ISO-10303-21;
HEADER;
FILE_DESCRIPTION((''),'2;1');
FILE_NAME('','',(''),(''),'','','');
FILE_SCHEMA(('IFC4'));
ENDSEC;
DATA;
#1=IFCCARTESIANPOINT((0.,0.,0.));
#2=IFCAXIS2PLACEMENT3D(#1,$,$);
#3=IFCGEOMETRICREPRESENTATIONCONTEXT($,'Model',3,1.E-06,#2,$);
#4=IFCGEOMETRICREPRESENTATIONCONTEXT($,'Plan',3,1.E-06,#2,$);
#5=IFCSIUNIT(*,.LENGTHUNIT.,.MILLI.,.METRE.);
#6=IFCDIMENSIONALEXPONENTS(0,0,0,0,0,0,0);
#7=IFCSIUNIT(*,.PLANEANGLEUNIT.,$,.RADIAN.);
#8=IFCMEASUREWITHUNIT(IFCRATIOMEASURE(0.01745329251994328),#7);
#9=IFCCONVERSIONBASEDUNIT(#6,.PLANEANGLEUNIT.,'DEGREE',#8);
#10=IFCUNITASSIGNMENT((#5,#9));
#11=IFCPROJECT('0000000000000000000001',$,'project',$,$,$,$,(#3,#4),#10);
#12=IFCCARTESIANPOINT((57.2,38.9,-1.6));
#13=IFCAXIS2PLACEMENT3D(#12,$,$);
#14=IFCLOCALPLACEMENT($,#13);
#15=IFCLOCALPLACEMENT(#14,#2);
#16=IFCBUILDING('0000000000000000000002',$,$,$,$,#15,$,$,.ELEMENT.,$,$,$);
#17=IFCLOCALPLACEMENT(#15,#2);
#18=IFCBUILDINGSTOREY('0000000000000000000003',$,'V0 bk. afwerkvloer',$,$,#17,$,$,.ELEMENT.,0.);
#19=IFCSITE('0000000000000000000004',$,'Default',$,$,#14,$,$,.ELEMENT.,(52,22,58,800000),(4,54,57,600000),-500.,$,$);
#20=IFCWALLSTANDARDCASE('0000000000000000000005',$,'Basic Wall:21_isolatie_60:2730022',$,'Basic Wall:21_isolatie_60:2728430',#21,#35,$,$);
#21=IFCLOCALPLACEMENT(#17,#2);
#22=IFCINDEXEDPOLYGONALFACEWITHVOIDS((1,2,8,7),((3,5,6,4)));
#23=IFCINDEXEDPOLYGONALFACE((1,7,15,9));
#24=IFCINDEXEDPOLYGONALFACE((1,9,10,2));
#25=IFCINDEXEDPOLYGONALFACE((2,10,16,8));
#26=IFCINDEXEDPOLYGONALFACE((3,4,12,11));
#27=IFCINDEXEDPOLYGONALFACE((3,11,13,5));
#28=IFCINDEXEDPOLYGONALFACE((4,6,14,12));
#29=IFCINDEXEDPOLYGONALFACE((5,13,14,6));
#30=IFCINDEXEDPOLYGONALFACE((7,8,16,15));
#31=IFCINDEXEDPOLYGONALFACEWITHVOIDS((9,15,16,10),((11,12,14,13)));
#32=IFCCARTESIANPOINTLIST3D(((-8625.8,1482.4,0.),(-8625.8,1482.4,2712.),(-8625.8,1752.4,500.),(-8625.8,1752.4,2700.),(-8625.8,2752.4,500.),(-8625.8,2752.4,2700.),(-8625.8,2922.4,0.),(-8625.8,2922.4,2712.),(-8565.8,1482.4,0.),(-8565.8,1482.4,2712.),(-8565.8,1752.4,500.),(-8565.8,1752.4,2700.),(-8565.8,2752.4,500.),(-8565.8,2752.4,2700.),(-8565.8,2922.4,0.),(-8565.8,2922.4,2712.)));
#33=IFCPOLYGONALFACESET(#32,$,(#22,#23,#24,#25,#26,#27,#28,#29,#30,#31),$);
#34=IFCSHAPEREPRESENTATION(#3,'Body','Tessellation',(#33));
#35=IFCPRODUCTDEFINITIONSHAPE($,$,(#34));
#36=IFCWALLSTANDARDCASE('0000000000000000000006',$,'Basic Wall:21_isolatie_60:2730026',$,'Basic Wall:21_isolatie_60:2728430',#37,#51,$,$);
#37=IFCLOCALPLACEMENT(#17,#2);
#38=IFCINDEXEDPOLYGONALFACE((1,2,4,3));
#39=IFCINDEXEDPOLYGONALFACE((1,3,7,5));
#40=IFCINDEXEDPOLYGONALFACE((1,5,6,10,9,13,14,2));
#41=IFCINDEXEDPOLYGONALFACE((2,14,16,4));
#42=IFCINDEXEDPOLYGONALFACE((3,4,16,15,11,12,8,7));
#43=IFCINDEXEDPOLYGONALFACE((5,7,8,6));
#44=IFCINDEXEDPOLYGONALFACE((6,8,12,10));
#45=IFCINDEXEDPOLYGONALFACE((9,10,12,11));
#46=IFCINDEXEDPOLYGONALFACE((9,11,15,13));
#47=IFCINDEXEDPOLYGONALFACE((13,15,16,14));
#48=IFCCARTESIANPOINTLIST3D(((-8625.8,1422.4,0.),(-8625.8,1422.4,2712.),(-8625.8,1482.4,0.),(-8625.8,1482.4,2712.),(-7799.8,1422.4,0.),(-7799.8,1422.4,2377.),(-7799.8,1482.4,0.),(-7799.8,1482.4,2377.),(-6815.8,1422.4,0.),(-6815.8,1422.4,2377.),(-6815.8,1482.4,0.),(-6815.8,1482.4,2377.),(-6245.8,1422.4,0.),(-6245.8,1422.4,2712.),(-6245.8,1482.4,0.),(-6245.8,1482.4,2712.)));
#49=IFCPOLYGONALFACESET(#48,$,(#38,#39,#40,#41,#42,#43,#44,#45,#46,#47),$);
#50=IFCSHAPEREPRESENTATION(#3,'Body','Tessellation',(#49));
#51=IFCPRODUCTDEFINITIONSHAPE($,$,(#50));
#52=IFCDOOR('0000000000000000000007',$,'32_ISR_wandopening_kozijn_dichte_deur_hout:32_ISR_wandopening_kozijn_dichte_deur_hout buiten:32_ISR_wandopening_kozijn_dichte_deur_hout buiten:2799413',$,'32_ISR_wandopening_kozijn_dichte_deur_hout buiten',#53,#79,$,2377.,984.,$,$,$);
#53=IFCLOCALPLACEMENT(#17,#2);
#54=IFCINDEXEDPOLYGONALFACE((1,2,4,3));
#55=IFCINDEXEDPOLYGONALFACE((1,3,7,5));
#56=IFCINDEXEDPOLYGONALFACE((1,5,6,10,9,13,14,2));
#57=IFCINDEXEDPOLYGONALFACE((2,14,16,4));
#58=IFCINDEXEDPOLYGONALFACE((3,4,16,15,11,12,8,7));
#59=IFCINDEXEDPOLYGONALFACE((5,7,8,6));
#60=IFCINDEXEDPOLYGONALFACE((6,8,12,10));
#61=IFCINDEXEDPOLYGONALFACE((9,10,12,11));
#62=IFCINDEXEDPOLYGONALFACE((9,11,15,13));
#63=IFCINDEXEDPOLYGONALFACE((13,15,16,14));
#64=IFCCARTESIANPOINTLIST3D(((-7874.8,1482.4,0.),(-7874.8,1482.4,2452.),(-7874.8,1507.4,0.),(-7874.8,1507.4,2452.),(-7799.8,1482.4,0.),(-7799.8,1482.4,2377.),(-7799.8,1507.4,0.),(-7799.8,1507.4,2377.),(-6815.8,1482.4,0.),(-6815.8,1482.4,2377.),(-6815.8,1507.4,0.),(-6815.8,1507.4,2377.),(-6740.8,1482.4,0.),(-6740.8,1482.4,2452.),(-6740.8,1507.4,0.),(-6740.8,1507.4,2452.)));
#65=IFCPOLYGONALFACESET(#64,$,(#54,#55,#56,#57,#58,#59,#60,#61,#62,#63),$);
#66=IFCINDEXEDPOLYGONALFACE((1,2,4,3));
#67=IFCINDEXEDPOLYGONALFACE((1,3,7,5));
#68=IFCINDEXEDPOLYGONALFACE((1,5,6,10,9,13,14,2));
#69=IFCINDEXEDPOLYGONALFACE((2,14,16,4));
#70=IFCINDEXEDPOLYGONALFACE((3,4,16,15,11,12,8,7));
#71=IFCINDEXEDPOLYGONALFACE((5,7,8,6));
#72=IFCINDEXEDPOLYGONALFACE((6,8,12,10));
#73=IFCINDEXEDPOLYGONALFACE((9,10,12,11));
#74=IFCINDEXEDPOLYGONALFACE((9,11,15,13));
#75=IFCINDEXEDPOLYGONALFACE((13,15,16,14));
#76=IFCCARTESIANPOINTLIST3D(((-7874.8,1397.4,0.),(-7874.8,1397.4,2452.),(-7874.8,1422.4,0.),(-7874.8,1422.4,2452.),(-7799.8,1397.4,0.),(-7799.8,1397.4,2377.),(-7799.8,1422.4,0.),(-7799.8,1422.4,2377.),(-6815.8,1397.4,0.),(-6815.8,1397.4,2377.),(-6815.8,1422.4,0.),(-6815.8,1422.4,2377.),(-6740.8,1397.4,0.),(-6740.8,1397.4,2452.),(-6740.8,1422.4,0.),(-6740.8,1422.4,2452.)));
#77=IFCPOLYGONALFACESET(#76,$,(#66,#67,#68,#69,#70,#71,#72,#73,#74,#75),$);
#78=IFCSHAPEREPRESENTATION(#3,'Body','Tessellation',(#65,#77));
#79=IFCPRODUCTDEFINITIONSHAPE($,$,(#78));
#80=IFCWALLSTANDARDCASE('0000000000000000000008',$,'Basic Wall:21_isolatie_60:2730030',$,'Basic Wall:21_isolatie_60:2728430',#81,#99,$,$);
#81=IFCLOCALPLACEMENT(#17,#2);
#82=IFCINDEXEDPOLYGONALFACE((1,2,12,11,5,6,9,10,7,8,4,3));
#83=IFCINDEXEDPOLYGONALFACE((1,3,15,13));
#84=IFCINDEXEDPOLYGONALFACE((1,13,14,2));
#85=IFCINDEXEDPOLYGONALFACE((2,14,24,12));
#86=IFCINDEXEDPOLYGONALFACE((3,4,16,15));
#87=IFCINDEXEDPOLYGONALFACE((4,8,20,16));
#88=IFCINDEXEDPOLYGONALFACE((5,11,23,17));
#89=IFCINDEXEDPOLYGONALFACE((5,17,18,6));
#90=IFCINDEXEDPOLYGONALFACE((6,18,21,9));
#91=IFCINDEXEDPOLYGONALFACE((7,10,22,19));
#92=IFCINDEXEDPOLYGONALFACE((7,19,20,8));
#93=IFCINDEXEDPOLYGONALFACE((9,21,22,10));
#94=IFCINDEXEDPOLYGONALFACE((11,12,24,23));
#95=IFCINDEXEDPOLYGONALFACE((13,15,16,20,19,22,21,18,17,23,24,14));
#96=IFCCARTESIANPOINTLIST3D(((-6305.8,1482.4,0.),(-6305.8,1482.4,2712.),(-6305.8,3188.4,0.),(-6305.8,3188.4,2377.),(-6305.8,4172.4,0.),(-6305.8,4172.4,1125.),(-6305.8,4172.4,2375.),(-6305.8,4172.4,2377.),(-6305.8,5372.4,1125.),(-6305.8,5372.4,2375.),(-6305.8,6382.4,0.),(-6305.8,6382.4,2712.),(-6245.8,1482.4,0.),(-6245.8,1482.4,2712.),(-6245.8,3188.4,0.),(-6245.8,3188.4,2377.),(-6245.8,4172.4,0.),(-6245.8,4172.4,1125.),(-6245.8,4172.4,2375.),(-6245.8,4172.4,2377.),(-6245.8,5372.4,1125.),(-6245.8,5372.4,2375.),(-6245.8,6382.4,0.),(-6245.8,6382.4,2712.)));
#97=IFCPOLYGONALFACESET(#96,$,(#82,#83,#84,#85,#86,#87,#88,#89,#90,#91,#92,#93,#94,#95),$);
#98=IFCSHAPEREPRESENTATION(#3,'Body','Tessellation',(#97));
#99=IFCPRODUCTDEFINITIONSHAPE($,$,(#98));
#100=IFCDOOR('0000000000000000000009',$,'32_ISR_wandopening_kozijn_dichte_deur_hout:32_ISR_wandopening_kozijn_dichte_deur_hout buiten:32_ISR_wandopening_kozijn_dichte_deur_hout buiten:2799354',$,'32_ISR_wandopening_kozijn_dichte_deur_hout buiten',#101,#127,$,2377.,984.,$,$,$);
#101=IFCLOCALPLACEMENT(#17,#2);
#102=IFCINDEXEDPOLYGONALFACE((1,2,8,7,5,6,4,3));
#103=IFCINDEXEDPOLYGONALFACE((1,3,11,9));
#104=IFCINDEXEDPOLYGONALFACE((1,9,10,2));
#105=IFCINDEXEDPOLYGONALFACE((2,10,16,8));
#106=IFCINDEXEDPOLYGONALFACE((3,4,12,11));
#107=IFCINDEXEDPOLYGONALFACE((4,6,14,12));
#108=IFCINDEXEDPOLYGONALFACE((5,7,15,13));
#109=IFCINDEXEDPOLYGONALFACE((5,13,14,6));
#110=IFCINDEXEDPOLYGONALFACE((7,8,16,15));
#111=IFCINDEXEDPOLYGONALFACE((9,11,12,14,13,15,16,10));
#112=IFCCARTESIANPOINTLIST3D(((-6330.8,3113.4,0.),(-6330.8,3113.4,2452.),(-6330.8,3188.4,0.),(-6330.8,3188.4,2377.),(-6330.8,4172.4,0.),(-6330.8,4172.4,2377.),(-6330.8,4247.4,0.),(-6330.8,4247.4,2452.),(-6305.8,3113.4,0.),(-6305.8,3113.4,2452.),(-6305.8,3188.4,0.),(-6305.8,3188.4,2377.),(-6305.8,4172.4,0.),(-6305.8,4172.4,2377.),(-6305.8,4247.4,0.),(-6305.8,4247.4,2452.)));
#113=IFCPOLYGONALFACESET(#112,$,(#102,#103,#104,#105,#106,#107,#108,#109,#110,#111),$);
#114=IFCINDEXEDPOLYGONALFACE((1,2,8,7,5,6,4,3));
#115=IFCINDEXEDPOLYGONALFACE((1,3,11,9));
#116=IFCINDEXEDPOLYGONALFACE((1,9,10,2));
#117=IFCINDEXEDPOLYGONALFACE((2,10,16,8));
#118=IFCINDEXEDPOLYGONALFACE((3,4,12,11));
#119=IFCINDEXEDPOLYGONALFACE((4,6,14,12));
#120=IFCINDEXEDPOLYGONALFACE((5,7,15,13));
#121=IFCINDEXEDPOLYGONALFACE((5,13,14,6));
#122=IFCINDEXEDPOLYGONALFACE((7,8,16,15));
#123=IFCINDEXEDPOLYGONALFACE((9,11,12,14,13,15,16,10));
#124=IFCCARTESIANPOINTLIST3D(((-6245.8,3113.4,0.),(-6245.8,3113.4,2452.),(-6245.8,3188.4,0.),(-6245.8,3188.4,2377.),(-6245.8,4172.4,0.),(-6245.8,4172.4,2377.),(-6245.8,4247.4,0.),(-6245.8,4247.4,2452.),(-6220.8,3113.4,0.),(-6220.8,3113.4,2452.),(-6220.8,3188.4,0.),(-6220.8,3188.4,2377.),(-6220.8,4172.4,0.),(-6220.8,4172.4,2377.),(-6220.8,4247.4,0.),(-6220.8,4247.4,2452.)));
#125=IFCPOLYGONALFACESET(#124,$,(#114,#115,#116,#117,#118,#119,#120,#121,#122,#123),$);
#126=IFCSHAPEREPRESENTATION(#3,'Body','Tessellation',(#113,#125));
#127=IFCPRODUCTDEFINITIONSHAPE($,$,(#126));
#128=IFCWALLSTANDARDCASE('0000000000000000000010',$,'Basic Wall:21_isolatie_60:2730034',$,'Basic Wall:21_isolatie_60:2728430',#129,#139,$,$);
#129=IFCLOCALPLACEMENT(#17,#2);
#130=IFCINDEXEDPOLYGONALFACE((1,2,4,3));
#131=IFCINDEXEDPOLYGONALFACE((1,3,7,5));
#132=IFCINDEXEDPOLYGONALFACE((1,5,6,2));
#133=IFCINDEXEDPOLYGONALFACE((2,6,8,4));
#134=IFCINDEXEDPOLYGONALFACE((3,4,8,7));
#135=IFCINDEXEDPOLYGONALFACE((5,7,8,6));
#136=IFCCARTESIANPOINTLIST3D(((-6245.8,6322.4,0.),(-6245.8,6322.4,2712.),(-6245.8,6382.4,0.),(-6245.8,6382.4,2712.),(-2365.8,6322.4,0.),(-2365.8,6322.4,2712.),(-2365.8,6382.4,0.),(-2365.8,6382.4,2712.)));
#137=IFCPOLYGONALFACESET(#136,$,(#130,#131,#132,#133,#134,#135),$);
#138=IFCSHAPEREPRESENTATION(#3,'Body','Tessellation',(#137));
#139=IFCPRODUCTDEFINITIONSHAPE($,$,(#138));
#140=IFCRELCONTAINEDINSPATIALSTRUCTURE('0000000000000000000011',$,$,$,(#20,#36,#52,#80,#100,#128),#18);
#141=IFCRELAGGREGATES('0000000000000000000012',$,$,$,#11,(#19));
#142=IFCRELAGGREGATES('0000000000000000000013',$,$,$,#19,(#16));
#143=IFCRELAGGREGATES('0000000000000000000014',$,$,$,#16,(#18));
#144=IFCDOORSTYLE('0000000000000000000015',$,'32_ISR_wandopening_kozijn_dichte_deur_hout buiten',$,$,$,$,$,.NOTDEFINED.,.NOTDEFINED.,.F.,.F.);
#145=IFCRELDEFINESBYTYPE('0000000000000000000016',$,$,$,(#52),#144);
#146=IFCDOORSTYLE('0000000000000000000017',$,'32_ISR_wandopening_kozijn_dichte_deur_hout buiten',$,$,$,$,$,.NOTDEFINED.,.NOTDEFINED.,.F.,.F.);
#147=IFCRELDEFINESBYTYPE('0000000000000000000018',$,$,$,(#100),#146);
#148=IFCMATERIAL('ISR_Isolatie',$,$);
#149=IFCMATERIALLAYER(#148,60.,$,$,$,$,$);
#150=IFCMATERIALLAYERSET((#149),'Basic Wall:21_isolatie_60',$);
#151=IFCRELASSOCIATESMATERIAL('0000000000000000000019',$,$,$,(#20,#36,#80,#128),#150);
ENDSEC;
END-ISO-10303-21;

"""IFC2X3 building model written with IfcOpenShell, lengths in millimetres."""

from ifc_helpers import new_model, entity, si_unit, converted_unit, frame, frame_2d, origin, origin_2d_with_axis, place, context, project, spatial, polyline, rectangle, outline, extrude, source, transform, mapped, material, layer, layer_set, layer_usage, type_object, type_shapes, element, fill, save


model = new_model("IFC2X3")

# Units and contexts
model_context = context("Model", 3, precision=1e-06, world=origin())
plan_context = context("Plan", 3, precision=1e-06, world=origin())
ifc_project = project(units=[si_unit("LENGTHUNIT", "METRE", prefix="MILLI"), converted_unit("PLANEANGLEUNIT", "DEGREE", entity("IfcRatioMeasure", 0.01745329251994328), si_unit("PLANEANGLEUNIT", "RADIAN"), dimensions=[0, 0, 0, 0, 0, 0, 0])], contexts=[model_context, plan_context])

# Site, building, storey
site_placement = place(None, frame((57.2, 38.9, -1.6)))
site = spatial("IfcSite", under=ifc_project, at=site_placement, Name="Default", CompositionType="ELEMENT", RefLatitude=(52, 22, 58, 800000), RefLongitude=(4, 54, 57, 600000), RefElevation=-500.0)
building_placement = place(site_placement, origin())
building = spatial("IfcBuilding", under=site, at=building_placement, CompositionType="ELEMENT")
storey_placement = place(building_placement, origin())
storey = spatial("IfcBuildingStorey", under=building, at=storey_placement, Name="V0 bk. afwerkvloer", CompositionType="ELEMENT", Elevation=0.0)

# Wall, opening
ifc_material_1 = material(Name="ISR_Isolatie")
ifc_layer_1 = layer(ifc_material_1, 60.0)
ifc_layer_set_1 = layer_set([ifc_layer_1], Name="Basic Wall:21_isolatie_60")
ifc_layer_usage_1 = layer_usage(ifc_layer_set_1, "AXIS2", "NEGATIVE", 30.0)
wall_1_placement = place(storey_placement, frame((-8595.8, 1482.4, 0.0), z_axis=(0.0, 0.0, 1.0), x_axis=(0.0, 1.0, 0.0)))
wall_1 = element("IfcWallStandardCase", 1, at=wall_1_placement, inside=storey, material=ifc_layer_usage_1, Name="Basic Wall:21_isolatie_60:2730022", ObjectType="Basic Wall:21_isolatie_60:2728430", context=model_context, shape_type="SweptSolid", body=[
    extrude(rectangle(XDim=1440.0, YDim=60.0, at=frame_2d((720.0, 0.0), x_axis=(-1.0, 0.0))), origin(), (0.0, 0.0, 1.0), 2712.0),
])
opening_1_placement = place(wall_1_placement, origin())
element("IfcOpeningElement", 2, at=opening_1_placement, cuts=wall_1, ObjectType="Opening", context=model_context, shape_type="SweptSolid", body=[
    extrude(rectangle(XDim=2200.0, YDim=1000.0, at=frame_2d((0.0, 0.0), x_axis=(0.0, 1.0))), frame((770.0, -182.4, 1600.0), z_axis=(0.0, 1.0, 0.0), x_axis=(-1.0, 0.0, 0.0)), (0.0, 0.0, 1.0), 364.8),
])

# Wall, opening, door
ifc_layer_usage_2 = layer_usage(ifc_layer_set_1, "AXIS2", "NEGATIVE", 30.0)
wall_2_placement = place(storey_placement, frame((-6245.8, 1452.4, 0.0), z_axis=(0.0, 0.0, 1.0), x_axis=(-1.0, 0.0, 0.0)))
wall_2 = element("IfcWallStandardCase", 3, at=wall_2_placement, inside=storey, material=ifc_layer_usage_2, Name="Basic Wall:21_isolatie_60:2730026", ObjectType="Basic Wall:21_isolatie_60:2728430", context=model_context, shape_type="SweptSolid", body=[
    extrude(rectangle(XDim=2380.0, YDim=60.0, at=frame_2d((1190.0, 0.0), x_axis=(-1.0, 0.0))), origin(), (0.0, 0.0, 1.0), 2712.0),
])
opening_2_placement = place(wall_2_placement, frame((1554.0, 30.0, 0.0)))
opening_2 = element("IfcOpeningElement", 4, at=opening_2_placement, cuts=wall_2, ObjectType="Opening", context=model_context, shape_type="SweptSolid", body=[
    extrude(rectangle(XDim=2377.0, YDim=984.0, at=frame_2d((1188.5, 492.0), x_axis=(1.0, 0.0))), frame((0.0, 0.0, 0.0), z_axis=(0.0, -1.0, 0.0), x_axis=(0.0, 0.0, 1.0)), (0.0, 0.0, 1.0), 60.0),
])
door_style_1 = type_object("IfcDoorStyle", Name="32_ISR_wandopening_kozijn_dichte_deur_hout buiten", ConstructionType="NOTDEFINED", OperationType="NOTDEFINED", ParameterTakesPrecedence=False, Sizeable=False)
shared_shape_1 = source(origin(), model_context, "Body", "SweptSolid", [
    extrude(outline(polyline([(-1169.7, 492.0), (1207.2, 492.0), (1207.2, 567.0), (-1244.7, 567.0), (-1244.7, -567.0), (1207.2, -567.0), (1207.2, -492.0), (-1169.7, -492.0), (-1169.7, 492.0)])), frame((492.0, 60.0, 1207.2), z_axis=(0.0, 1.0, 0.0), x_axis=(0.0, 0.0, -1.0)), (0.0, 0.0, 1.0), 25.0),
    extrude(outline(polyline([(-567.0, -1244.7), (567.0, -1244.7), (567.0, 1207.2), (492.0, 1207.2), (492.0, -1169.7), (-492.0, -1169.7), (-492.0, 1207.2), (-567.0, 1207.2), (-567.0, -1244.7)])), frame((492.0, -25.0, 1207.2), z_axis=(0.0, 1.0, 0.0), x_axis=(1.0, 0.0, 0.0)), (0.0, 0.0, 1.0), 25.0),
])
type_shapes(door_style_1, [shared_shape_1])
door_1_placement = place(opening_2_placement, frame((0.0, 0.0, 0.0), z_axis=(0.0, 0.0, 1.0), x_axis=(-1.0, 0.0, 0.0)))
door_1 = element("IfcDoor", 5, at=door_1_placement, inside=storey, type_object=door_style_1, Name="32_ISR_wandopening_kozijn_dichte_deur_hout:32_ISR_wandopening_kozijn_dichte_deur_hout buiten:32_ISR_wandopening_kozijn_dichte_deur_hout buiten:2799413", ObjectType="32_ISR_wandopening_kozijn_dichte_deur_hout buiten", OverallHeight=2377.0, OverallWidth=984.0, context=model_context, shape_type="MappedRepresentation", body=[
    mapped(shared_shape_1, transform((0.0, 0.0, 0.0), scale=1.0)),
])
fill(opening_2, door_1)

# Wall, openings, door
ifc_layer_usage_3 = layer_usage(ifc_layer_set_1, "AXIS2", "NEGATIVE", 30.0)
wall_3_placement = place(storey_placement, frame((-6275.8, 6382.4, 0.0), z_axis=(0.0, 0.0, 1.0), x_axis=(0.0, -1.0, 0.0)))
wall_3 = element("IfcWallStandardCase", 6, at=wall_3_placement, inside=storey, material=ifc_layer_usage_3, Name="Basic Wall:21_isolatie_60:2730030", ObjectType="Basic Wall:21_isolatie_60:2728430", context=model_context, shape_type="SweptSolid", body=[
    extrude(rectangle(XDim=4900.0, YDim=60.0, at=frame_2d((2450.0, 0.0), x_axis=(-1.0, 0.0))), origin(), (0.0, 0.0, 1.0), 2712.0),
])
opening_3_placement = place(wall_3_placement, origin())
element("IfcOpeningElement", 7, at=opening_3_placement, cuts=wall_3, ObjectType="Opening", context=model_context, shape_type="SweptSolid", body=[
    extrude(rectangle(XDim=1250.0, YDim=1200.0, at=origin_2d_with_axis()), frame((1610.0, -182.4, 1750.0), z_axis=(0.0, 1.0, 0.0), x_axis=(0.0, 0.0, 1.0)), (0.0, 0.0, 1.0), 364.8),
])
opening_4_placement = place(wall_3_placement, frame((3194.0, 30.0, 0.0)))
opening_4 = element("IfcOpeningElement", 8, at=opening_4_placement, cuts=wall_3, ObjectType="Opening", context=model_context, shape_type="SweptSolid", body=[
    extrude(rectangle(XDim=2377.0, YDim=984.0, at=frame_2d((1188.5, 492.0), x_axis=(1.0, 0.0))), frame((0.0, 0.0, 0.0), z_axis=(0.0, -1.0, 0.0), x_axis=(0.0, 0.0, 1.0)), (0.0, 0.0, 1.0), 60.0),
])
door_style_2 = type_object("IfcDoorStyle", Name="32_ISR_wandopening_kozijn_dichte_deur_hout buiten", ConstructionType="NOTDEFINED", OperationType="NOTDEFINED", ParameterTakesPrecedence=False, Sizeable=False)
shared_shape_2 = source(origin(), model_context, "Body", "SweptSolid", [
    extrude(outline(polyline([(-1169.7, 492.0), (1207.2, 492.0), (1207.2, 567.0), (-1244.7, 567.0), (-1244.7, -567.0), (1207.2, -567.0), (1207.2, -492.0), (-1169.7, -492.0), (-1169.7, 492.0)])), frame((1202.0, 85.0, 1207.2), z_axis=(0.0, -1.0, 0.0), x_axis=(0.0, 0.0, -1.0)), (0.0, 0.0, 1.0), 25.0),
    extrude(outline(polyline([(-567.0, -1244.7), (567.0, -1244.7), (567.0, 1207.2), (492.0, 1207.2), (492.0, -1169.7), (-492.0, -1169.7), (-492.0, 1207.2), (-567.0, 1207.2), (-567.0, -1244.7)])), frame((1202.0, 0.0, 1207.2), z_axis=(0.0, -1.0, 0.0), x_axis=(-1.0, 0.0, 0.0)), (0.0, 0.0, 1.0), 25.0),
])
type_shapes(door_style_2, [shared_shape_2])
door_2_placement = place(opening_4_placement, frame((710.0, 0.0, 0.0), z_axis=(0.0, 0.0, 1.0), x_axis=(-1.0, 0.0, 0.0)))
door_2 = element("IfcDoor", 9, at=door_2_placement, inside=storey, type_object=door_style_2, Name="32_ISR_wandopening_kozijn_dichte_deur_hout:32_ISR_wandopening_kozijn_dichte_deur_hout buiten:32_ISR_wandopening_kozijn_dichte_deur_hout buiten:2799354", ObjectType="32_ISR_wandopening_kozijn_dichte_deur_hout buiten", OverallHeight=2377.0, OverallWidth=984.0, context=model_context, shape_type="MappedRepresentation", body=[
    mapped(shared_shape_2, transform((0.0, 0.0, 0.0), scale=1.0)),
])
fill(opening_4, door_2)

# Wall
ifc_layer_usage_4 = layer_usage(ifc_layer_set_1, "AXIS2", "NEGATIVE", 30.0)
wall_4_placement = place(storey_placement, frame((-2365.8, 6352.4, 0.0), z_axis=(0.0, 0.0, 1.0), x_axis=(-1.0, 0.0, 0.0)))
element("IfcWallStandardCase", 10, at=wall_4_placement, inside=storey, material=ifc_layer_usage_4, Name="Basic Wall:21_isolatie_60:2730034", ObjectType="Basic Wall:21_isolatie_60:2728430", context=model_context, shape_type="SweptSolid", body=[
    extrude(rectangle(XDim=3880.0, YDim=60.0, at=frame_2d((1940.0, 0.0), x_axis=(-1.0, 0.0))), origin(), (0.0, 0.0, 1.0), 2712.0),
])

save(model, "model.ifc")
